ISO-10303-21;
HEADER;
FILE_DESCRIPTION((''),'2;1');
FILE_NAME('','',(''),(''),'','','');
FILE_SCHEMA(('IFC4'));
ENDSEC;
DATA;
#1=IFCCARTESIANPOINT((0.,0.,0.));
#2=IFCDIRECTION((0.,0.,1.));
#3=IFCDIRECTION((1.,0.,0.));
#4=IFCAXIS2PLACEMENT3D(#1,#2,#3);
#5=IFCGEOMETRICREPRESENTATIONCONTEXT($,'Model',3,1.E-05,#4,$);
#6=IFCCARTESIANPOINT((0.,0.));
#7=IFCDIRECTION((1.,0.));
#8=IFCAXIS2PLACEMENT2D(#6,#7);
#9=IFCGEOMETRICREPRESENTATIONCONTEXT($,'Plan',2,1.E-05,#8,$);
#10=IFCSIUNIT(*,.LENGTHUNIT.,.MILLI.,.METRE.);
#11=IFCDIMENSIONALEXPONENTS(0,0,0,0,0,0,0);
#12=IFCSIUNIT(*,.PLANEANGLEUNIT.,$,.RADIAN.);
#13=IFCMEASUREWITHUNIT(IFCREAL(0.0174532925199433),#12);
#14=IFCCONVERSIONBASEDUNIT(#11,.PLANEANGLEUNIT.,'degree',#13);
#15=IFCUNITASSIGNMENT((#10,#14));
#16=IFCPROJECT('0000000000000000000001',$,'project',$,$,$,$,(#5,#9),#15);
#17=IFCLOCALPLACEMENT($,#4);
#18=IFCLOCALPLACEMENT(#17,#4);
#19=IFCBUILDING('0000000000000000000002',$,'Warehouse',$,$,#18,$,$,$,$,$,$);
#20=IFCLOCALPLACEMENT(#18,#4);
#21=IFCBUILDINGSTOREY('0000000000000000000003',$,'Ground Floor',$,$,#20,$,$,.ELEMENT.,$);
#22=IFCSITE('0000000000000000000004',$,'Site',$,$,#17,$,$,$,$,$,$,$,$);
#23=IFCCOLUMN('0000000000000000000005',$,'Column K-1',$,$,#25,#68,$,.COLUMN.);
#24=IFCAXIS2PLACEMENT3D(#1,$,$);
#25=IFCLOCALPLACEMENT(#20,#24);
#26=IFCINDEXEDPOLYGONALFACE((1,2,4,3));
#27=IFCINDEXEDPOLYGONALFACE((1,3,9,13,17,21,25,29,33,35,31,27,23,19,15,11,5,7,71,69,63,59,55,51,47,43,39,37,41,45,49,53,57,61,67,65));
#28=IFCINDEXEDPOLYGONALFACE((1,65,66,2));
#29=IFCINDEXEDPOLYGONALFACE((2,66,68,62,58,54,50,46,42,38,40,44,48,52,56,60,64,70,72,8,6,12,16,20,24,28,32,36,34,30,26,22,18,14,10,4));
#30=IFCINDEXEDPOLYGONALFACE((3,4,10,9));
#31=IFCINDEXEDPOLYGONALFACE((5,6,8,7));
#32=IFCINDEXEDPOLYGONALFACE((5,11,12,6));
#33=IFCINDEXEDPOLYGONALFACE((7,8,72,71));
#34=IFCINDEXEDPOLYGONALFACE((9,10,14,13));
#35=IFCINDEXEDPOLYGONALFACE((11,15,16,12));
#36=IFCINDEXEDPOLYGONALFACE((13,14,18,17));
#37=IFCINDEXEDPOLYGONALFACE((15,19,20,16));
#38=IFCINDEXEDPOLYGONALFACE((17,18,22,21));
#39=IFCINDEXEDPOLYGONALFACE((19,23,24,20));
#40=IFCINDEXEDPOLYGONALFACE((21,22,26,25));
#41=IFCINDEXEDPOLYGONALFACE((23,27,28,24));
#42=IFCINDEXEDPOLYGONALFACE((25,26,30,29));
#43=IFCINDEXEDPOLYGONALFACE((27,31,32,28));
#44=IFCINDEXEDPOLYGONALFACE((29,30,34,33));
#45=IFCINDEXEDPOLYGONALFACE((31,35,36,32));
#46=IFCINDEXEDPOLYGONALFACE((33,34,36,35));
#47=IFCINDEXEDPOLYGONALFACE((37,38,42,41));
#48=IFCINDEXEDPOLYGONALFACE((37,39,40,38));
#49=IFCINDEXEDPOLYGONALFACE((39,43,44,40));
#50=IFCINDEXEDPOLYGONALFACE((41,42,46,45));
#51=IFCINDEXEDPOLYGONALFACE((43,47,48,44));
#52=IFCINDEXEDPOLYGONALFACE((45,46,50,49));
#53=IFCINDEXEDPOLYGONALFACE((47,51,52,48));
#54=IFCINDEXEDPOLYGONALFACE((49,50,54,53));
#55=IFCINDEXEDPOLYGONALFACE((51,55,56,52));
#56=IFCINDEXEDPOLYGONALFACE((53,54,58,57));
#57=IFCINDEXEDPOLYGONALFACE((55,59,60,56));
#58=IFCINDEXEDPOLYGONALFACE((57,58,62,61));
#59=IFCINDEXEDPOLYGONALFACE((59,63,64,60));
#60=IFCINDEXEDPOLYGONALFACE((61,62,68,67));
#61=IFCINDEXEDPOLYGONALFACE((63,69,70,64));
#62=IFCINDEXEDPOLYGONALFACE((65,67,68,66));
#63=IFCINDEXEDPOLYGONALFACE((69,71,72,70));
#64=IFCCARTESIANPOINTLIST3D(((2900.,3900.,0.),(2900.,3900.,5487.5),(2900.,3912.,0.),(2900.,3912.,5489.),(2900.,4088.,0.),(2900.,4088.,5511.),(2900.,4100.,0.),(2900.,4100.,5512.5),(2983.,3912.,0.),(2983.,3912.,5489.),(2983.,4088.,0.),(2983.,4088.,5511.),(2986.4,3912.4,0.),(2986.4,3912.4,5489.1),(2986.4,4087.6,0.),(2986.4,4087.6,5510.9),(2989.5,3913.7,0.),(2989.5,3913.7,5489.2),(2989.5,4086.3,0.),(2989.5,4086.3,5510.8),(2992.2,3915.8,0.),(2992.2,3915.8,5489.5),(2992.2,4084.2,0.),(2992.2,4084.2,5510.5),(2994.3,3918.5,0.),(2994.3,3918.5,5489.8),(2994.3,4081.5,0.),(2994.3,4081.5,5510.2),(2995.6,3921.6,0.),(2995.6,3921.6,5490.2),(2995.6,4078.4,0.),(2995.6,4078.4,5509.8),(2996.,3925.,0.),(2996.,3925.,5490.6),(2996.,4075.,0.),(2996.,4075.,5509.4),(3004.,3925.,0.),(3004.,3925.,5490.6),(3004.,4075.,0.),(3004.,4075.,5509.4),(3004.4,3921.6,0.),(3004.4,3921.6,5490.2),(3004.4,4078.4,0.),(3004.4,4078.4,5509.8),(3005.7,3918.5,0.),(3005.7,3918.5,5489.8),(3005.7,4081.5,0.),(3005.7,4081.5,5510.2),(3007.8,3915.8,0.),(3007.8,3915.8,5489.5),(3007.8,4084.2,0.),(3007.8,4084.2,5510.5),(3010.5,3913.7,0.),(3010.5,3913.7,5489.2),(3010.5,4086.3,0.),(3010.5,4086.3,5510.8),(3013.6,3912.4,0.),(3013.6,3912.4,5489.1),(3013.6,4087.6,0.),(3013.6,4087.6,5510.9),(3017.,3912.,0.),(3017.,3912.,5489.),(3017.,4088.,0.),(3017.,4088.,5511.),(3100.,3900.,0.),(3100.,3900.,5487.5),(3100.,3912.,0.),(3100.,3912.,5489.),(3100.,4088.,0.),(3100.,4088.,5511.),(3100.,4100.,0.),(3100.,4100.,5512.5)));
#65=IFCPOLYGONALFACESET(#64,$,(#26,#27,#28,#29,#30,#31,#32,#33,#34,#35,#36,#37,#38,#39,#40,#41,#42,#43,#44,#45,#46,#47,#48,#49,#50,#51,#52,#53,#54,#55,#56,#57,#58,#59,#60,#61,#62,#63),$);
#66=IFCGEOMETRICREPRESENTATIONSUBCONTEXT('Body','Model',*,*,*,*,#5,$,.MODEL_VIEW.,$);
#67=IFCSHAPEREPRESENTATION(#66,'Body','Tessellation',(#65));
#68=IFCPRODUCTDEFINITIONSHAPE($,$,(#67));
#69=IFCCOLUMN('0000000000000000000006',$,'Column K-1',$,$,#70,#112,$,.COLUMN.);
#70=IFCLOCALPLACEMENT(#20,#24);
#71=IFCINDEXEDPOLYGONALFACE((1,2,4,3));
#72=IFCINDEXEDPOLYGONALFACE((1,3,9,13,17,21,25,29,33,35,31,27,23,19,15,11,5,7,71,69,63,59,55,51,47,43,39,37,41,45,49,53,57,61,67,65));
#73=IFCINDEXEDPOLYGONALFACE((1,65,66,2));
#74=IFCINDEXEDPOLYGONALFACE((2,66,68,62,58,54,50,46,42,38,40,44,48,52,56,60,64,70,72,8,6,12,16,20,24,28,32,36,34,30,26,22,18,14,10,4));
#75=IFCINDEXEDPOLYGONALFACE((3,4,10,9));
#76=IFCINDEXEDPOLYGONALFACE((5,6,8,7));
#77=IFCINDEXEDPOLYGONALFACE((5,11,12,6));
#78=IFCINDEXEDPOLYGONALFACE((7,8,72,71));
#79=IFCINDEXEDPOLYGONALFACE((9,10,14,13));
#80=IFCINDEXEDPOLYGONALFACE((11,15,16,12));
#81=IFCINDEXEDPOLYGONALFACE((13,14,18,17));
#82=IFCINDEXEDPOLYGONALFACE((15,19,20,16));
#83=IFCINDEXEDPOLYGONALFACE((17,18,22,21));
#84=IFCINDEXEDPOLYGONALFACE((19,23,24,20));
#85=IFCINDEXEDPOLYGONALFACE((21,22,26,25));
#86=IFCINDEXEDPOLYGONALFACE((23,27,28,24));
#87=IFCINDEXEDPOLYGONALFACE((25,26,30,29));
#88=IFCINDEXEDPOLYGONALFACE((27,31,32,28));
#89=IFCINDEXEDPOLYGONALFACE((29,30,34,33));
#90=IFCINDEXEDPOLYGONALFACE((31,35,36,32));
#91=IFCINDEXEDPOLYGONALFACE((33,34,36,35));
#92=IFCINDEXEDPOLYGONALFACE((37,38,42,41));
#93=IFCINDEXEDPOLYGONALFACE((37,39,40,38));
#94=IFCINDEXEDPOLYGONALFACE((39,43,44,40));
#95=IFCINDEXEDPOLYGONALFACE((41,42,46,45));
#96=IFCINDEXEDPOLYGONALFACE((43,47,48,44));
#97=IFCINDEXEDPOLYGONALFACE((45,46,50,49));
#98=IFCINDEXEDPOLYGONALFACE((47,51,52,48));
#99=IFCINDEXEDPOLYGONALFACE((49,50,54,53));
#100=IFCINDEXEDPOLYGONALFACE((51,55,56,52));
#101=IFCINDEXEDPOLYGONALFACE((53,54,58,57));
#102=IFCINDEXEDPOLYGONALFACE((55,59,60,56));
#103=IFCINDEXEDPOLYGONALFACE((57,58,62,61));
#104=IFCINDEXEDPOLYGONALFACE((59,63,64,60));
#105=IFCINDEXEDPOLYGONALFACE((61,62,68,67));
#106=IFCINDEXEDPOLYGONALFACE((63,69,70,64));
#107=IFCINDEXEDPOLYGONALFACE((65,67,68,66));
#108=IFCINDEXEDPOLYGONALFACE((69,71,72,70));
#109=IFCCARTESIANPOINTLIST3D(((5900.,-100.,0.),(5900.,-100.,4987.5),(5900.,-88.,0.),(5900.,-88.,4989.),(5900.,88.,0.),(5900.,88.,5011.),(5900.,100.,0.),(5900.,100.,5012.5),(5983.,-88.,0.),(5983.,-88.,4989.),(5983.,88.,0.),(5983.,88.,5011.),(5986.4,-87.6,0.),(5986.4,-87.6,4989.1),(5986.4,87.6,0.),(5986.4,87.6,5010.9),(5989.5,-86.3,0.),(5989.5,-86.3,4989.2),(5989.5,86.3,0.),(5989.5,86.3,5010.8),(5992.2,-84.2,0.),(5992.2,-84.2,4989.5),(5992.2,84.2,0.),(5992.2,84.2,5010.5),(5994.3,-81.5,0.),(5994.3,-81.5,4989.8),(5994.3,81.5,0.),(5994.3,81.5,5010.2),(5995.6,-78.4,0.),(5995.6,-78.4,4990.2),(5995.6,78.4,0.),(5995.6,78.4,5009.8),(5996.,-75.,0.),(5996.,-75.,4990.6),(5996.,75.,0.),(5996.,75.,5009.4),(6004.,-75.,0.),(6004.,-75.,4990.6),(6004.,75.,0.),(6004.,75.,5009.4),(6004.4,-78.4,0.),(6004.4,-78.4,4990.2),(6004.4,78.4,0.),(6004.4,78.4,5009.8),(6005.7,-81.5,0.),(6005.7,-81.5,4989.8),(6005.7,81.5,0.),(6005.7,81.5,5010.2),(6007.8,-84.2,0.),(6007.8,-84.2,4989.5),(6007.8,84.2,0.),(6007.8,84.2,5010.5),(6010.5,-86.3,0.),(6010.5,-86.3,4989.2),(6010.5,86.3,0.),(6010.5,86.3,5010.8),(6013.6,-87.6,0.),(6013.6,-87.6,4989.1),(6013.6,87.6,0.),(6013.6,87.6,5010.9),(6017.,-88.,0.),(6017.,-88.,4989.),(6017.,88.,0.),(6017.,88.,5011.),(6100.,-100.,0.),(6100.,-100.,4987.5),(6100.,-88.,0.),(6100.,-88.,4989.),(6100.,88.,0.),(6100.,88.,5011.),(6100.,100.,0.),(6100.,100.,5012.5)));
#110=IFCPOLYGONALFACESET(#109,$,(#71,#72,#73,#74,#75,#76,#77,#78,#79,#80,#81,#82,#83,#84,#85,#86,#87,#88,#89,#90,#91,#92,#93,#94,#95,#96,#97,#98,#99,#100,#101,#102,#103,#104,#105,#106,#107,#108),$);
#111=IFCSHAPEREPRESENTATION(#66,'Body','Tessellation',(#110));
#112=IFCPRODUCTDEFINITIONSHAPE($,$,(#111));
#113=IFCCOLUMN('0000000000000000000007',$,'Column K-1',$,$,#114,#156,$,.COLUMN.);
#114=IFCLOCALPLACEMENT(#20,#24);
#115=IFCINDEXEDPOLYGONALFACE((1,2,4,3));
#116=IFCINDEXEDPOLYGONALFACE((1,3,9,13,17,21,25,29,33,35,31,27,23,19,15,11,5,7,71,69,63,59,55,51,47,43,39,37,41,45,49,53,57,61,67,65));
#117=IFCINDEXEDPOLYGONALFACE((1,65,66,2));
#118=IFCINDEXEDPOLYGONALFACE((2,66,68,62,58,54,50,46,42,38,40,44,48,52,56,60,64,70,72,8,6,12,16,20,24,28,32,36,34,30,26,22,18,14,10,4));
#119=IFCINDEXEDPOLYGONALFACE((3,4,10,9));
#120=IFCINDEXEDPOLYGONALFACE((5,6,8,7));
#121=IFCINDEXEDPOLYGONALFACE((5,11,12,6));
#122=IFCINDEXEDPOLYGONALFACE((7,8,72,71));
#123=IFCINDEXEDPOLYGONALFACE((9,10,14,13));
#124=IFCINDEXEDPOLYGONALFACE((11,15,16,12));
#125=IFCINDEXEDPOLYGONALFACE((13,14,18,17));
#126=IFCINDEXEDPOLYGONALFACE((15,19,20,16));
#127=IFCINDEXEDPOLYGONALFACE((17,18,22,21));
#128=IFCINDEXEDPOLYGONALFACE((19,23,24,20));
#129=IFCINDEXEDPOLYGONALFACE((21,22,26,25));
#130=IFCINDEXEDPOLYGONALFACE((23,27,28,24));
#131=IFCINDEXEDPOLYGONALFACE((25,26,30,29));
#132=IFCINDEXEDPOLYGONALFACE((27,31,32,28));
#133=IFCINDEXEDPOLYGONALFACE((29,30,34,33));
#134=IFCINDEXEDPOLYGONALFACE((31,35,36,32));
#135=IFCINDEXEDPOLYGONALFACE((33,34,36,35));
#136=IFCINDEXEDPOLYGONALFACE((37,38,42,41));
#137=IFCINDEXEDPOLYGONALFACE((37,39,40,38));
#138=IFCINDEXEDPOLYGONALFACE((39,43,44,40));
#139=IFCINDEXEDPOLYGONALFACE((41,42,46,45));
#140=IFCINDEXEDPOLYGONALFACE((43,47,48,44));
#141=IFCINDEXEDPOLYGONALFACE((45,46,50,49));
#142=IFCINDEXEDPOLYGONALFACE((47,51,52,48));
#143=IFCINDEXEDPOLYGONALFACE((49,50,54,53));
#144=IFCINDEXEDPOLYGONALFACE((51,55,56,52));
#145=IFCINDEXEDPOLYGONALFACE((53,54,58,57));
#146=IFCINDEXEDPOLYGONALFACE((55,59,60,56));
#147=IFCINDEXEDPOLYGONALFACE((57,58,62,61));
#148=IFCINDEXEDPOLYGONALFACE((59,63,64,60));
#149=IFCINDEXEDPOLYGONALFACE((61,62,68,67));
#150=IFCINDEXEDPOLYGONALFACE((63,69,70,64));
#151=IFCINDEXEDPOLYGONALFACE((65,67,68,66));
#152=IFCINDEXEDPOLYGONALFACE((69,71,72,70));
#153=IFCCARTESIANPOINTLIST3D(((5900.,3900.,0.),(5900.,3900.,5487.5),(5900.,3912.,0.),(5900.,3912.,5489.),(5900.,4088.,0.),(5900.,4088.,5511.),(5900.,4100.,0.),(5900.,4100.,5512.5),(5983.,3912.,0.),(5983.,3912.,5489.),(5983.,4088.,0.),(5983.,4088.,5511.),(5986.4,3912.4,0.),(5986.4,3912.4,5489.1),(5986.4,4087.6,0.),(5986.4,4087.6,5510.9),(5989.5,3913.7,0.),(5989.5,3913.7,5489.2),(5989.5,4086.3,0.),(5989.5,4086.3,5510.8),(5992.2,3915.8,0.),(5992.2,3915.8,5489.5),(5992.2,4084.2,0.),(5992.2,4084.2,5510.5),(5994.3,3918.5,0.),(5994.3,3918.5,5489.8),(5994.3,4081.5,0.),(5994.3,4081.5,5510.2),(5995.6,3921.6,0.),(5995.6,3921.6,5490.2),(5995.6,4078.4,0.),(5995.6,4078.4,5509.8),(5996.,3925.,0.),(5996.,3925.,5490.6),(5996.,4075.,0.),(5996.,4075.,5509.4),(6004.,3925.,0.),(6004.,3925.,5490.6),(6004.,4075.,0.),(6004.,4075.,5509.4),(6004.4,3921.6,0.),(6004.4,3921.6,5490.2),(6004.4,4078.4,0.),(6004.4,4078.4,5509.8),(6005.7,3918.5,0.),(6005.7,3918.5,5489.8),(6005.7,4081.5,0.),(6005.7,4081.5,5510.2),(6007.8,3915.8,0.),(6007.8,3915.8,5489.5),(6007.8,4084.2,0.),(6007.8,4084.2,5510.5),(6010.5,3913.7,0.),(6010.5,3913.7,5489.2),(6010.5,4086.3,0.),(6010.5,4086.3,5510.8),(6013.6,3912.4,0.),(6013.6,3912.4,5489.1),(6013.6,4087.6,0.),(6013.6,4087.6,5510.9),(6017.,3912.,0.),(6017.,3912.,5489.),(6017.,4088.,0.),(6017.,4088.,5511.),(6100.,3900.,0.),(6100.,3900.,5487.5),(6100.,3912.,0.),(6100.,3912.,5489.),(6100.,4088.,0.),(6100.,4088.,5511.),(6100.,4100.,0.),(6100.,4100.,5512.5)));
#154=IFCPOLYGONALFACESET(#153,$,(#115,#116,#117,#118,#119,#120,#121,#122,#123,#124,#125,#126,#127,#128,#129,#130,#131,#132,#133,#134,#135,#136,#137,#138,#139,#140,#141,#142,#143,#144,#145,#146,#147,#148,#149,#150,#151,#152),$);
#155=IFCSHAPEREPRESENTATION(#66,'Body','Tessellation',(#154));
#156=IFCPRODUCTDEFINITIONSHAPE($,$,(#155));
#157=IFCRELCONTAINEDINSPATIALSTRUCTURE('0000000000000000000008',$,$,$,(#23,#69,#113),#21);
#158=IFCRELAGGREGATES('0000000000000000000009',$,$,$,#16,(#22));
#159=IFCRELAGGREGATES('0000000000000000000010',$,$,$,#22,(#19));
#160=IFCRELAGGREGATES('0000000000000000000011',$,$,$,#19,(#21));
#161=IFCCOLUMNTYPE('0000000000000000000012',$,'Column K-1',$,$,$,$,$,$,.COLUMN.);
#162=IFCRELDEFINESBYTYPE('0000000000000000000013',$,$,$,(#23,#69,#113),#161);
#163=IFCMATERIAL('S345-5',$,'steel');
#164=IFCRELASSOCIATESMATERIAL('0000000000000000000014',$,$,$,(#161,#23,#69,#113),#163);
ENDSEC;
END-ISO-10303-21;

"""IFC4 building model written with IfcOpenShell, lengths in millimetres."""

from ifc_helpers import new_model, entity, si_unit, converted_unit, frame, origin_with_axes, origin_2d_with_axis, place, context, subcontext, project, spatial, i_section, extrude, clip, halfspace, material, material_profile, profile_set, profile_usage, type_object, element, save


model = new_model("IFC4")

# Units and contexts
model_context = context("Model", 3, precision=1e-05, world=origin_with_axes())
plan_context = context("Plan", 2, precision=1e-05, world=origin_2d_with_axis())
body_context = subcontext(model_context, "Body", "Model", "MODEL_VIEW")
ifc_project = project(units=[si_unit("LENGTHUNIT", "METRE", prefix="MILLI"), converted_unit("PLANEANGLEUNIT", "degree", entity("IfcReal", 0.0174532925199433), si_unit("PLANEANGLEUNIT", "RADIAN"), dimensions=[0, 0, 0, 0, 0, 0, 0])], contexts=[model_context, plan_context])

# Site, building, storey
site_placement = place(None, origin_with_axes())
site = spatial("IfcSite", under=ifc_project, at=site_placement, Name="Site")
building_placement = place(site_placement, origin_with_axes())
building = spatial("IfcBuilding", under=site, at=building_placement, Name="Warehouse")
storey_placement = place(building_placement, origin_with_axes())
storey = spatial("IfcBuildingStorey", under=building, at=storey_placement, Name="Ground Floor", CompositionType="ELEMENT")

# Columns
ifc_material_1 = material(Name="S345-5", Category="steel")
ifc_material_profile_1 = material_profile(ifc_material_1, i_section(OverallWidth=200.0, OverallDepth=200.0, WebThickness=8.0, FlangeThickness=12.0, FilletRadius=13.0, FlangeEdgeRadius=0.0, FlangeSlope=0.0))
ifc_profile_set_1 = profile_set([ifc_material_profile_1], Name="I20K2_S345-5")
column_type = type_object("IfcColumnType", Name="Column K-1", PredefinedType="COLUMN", material=ifc_profile_set_1)
ifc_profile_usage_1 = profile_usage(ifc_profile_set_1, cardinal=5)
column_1_placement = place(storey_placement, frame((3000.0, 4000.0, 0.0), z_axis=(0.0, 0.0, 1.0), x_axis=(1.0, 0.0, 0.0)))
element("IfcColumn", 1, at=column_1_placement, inside=storey, type_object=column_type, material=ifc_profile_usage_1, Name="Column K-1", PredefinedType="COLUMN", context=body_context, shape_type="Clipping", body=[
    clip(extrude(i_section(OverallWidth=200.0, OverallDepth=200.0, WebThickness=8.0, FlangeThickness=12.0, FilletRadius=13.0, FlangeEdgeRadius=0.0, FlangeSlope=0.0), origin_with_axes(), (0.0, 0.0, 1.0), 5700.0), halfspace(frame((0.0, -4298.5, 4962.7), z_axis=(0.0, -0.124035, 0.992278), x_axis=(0.0, 0.992278, 0.124035)), False)),
])
ifc_profile_usage_2 = profile_usage(ifc_profile_set_1, cardinal=5)
column_2_placement = place(storey_placement, frame((6000.0, 0.0, 0.0), z_axis=(0.0, 0.0, 1.0), x_axis=(1.0, 0.0, 0.0)))
element("IfcColumn", 2, at=column_2_placement, inside=storey, type_object=column_type, material=ifc_profile_usage_2, Name="Column K-1", PredefinedType="COLUMN", context=body_context, shape_type="Clipping", body=[
    clip(extrude(i_section(OverallWidth=200.0, OverallDepth=200.0, WebThickness=8.0, FlangeThickness=12.0, FilletRadius=13.0, FlangeEdgeRadius=0.0, FlangeSlope=0.0), origin_with_axes(), (0.0, 0.0, 1.0), 5200.0), halfspace(frame((0.0, -298.5, 4962.7), z_axis=(0.0, -0.124035, 0.992278), x_axis=(0.0, 0.992278, 0.124035)), False)),
])
ifc_profile_usage_3 = profile_usage(ifc_profile_set_1, cardinal=5)
column_3_placement = place(storey_placement, frame((6000.0, 4000.0, 0.0), z_axis=(0.0, 0.0, 1.0), x_axis=(1.0, 0.0, 0.0)))
element("IfcColumn", 3, at=column_3_placement, inside=storey, type_object=column_type, material=ifc_profile_usage_3, Name="Column K-1", PredefinedType="COLUMN", context=body_context, shape_type="Clipping", body=[
    clip(extrude(i_section(OverallWidth=200.0, OverallDepth=200.0, WebThickness=8.0, FlangeThickness=12.0, FilletRadius=13.0, FlangeEdgeRadius=0.0, FlangeSlope=0.0), origin_with_axes(), (0.0, 0.0, 1.0), 5700.0), halfspace(frame((0.0, -4298.5, 4962.7), z_axis=(0.0, -0.124035, 0.992278), x_axis=(0.0, 0.992278, 0.124035)), False)),
])

save(model, "model.ifc")
